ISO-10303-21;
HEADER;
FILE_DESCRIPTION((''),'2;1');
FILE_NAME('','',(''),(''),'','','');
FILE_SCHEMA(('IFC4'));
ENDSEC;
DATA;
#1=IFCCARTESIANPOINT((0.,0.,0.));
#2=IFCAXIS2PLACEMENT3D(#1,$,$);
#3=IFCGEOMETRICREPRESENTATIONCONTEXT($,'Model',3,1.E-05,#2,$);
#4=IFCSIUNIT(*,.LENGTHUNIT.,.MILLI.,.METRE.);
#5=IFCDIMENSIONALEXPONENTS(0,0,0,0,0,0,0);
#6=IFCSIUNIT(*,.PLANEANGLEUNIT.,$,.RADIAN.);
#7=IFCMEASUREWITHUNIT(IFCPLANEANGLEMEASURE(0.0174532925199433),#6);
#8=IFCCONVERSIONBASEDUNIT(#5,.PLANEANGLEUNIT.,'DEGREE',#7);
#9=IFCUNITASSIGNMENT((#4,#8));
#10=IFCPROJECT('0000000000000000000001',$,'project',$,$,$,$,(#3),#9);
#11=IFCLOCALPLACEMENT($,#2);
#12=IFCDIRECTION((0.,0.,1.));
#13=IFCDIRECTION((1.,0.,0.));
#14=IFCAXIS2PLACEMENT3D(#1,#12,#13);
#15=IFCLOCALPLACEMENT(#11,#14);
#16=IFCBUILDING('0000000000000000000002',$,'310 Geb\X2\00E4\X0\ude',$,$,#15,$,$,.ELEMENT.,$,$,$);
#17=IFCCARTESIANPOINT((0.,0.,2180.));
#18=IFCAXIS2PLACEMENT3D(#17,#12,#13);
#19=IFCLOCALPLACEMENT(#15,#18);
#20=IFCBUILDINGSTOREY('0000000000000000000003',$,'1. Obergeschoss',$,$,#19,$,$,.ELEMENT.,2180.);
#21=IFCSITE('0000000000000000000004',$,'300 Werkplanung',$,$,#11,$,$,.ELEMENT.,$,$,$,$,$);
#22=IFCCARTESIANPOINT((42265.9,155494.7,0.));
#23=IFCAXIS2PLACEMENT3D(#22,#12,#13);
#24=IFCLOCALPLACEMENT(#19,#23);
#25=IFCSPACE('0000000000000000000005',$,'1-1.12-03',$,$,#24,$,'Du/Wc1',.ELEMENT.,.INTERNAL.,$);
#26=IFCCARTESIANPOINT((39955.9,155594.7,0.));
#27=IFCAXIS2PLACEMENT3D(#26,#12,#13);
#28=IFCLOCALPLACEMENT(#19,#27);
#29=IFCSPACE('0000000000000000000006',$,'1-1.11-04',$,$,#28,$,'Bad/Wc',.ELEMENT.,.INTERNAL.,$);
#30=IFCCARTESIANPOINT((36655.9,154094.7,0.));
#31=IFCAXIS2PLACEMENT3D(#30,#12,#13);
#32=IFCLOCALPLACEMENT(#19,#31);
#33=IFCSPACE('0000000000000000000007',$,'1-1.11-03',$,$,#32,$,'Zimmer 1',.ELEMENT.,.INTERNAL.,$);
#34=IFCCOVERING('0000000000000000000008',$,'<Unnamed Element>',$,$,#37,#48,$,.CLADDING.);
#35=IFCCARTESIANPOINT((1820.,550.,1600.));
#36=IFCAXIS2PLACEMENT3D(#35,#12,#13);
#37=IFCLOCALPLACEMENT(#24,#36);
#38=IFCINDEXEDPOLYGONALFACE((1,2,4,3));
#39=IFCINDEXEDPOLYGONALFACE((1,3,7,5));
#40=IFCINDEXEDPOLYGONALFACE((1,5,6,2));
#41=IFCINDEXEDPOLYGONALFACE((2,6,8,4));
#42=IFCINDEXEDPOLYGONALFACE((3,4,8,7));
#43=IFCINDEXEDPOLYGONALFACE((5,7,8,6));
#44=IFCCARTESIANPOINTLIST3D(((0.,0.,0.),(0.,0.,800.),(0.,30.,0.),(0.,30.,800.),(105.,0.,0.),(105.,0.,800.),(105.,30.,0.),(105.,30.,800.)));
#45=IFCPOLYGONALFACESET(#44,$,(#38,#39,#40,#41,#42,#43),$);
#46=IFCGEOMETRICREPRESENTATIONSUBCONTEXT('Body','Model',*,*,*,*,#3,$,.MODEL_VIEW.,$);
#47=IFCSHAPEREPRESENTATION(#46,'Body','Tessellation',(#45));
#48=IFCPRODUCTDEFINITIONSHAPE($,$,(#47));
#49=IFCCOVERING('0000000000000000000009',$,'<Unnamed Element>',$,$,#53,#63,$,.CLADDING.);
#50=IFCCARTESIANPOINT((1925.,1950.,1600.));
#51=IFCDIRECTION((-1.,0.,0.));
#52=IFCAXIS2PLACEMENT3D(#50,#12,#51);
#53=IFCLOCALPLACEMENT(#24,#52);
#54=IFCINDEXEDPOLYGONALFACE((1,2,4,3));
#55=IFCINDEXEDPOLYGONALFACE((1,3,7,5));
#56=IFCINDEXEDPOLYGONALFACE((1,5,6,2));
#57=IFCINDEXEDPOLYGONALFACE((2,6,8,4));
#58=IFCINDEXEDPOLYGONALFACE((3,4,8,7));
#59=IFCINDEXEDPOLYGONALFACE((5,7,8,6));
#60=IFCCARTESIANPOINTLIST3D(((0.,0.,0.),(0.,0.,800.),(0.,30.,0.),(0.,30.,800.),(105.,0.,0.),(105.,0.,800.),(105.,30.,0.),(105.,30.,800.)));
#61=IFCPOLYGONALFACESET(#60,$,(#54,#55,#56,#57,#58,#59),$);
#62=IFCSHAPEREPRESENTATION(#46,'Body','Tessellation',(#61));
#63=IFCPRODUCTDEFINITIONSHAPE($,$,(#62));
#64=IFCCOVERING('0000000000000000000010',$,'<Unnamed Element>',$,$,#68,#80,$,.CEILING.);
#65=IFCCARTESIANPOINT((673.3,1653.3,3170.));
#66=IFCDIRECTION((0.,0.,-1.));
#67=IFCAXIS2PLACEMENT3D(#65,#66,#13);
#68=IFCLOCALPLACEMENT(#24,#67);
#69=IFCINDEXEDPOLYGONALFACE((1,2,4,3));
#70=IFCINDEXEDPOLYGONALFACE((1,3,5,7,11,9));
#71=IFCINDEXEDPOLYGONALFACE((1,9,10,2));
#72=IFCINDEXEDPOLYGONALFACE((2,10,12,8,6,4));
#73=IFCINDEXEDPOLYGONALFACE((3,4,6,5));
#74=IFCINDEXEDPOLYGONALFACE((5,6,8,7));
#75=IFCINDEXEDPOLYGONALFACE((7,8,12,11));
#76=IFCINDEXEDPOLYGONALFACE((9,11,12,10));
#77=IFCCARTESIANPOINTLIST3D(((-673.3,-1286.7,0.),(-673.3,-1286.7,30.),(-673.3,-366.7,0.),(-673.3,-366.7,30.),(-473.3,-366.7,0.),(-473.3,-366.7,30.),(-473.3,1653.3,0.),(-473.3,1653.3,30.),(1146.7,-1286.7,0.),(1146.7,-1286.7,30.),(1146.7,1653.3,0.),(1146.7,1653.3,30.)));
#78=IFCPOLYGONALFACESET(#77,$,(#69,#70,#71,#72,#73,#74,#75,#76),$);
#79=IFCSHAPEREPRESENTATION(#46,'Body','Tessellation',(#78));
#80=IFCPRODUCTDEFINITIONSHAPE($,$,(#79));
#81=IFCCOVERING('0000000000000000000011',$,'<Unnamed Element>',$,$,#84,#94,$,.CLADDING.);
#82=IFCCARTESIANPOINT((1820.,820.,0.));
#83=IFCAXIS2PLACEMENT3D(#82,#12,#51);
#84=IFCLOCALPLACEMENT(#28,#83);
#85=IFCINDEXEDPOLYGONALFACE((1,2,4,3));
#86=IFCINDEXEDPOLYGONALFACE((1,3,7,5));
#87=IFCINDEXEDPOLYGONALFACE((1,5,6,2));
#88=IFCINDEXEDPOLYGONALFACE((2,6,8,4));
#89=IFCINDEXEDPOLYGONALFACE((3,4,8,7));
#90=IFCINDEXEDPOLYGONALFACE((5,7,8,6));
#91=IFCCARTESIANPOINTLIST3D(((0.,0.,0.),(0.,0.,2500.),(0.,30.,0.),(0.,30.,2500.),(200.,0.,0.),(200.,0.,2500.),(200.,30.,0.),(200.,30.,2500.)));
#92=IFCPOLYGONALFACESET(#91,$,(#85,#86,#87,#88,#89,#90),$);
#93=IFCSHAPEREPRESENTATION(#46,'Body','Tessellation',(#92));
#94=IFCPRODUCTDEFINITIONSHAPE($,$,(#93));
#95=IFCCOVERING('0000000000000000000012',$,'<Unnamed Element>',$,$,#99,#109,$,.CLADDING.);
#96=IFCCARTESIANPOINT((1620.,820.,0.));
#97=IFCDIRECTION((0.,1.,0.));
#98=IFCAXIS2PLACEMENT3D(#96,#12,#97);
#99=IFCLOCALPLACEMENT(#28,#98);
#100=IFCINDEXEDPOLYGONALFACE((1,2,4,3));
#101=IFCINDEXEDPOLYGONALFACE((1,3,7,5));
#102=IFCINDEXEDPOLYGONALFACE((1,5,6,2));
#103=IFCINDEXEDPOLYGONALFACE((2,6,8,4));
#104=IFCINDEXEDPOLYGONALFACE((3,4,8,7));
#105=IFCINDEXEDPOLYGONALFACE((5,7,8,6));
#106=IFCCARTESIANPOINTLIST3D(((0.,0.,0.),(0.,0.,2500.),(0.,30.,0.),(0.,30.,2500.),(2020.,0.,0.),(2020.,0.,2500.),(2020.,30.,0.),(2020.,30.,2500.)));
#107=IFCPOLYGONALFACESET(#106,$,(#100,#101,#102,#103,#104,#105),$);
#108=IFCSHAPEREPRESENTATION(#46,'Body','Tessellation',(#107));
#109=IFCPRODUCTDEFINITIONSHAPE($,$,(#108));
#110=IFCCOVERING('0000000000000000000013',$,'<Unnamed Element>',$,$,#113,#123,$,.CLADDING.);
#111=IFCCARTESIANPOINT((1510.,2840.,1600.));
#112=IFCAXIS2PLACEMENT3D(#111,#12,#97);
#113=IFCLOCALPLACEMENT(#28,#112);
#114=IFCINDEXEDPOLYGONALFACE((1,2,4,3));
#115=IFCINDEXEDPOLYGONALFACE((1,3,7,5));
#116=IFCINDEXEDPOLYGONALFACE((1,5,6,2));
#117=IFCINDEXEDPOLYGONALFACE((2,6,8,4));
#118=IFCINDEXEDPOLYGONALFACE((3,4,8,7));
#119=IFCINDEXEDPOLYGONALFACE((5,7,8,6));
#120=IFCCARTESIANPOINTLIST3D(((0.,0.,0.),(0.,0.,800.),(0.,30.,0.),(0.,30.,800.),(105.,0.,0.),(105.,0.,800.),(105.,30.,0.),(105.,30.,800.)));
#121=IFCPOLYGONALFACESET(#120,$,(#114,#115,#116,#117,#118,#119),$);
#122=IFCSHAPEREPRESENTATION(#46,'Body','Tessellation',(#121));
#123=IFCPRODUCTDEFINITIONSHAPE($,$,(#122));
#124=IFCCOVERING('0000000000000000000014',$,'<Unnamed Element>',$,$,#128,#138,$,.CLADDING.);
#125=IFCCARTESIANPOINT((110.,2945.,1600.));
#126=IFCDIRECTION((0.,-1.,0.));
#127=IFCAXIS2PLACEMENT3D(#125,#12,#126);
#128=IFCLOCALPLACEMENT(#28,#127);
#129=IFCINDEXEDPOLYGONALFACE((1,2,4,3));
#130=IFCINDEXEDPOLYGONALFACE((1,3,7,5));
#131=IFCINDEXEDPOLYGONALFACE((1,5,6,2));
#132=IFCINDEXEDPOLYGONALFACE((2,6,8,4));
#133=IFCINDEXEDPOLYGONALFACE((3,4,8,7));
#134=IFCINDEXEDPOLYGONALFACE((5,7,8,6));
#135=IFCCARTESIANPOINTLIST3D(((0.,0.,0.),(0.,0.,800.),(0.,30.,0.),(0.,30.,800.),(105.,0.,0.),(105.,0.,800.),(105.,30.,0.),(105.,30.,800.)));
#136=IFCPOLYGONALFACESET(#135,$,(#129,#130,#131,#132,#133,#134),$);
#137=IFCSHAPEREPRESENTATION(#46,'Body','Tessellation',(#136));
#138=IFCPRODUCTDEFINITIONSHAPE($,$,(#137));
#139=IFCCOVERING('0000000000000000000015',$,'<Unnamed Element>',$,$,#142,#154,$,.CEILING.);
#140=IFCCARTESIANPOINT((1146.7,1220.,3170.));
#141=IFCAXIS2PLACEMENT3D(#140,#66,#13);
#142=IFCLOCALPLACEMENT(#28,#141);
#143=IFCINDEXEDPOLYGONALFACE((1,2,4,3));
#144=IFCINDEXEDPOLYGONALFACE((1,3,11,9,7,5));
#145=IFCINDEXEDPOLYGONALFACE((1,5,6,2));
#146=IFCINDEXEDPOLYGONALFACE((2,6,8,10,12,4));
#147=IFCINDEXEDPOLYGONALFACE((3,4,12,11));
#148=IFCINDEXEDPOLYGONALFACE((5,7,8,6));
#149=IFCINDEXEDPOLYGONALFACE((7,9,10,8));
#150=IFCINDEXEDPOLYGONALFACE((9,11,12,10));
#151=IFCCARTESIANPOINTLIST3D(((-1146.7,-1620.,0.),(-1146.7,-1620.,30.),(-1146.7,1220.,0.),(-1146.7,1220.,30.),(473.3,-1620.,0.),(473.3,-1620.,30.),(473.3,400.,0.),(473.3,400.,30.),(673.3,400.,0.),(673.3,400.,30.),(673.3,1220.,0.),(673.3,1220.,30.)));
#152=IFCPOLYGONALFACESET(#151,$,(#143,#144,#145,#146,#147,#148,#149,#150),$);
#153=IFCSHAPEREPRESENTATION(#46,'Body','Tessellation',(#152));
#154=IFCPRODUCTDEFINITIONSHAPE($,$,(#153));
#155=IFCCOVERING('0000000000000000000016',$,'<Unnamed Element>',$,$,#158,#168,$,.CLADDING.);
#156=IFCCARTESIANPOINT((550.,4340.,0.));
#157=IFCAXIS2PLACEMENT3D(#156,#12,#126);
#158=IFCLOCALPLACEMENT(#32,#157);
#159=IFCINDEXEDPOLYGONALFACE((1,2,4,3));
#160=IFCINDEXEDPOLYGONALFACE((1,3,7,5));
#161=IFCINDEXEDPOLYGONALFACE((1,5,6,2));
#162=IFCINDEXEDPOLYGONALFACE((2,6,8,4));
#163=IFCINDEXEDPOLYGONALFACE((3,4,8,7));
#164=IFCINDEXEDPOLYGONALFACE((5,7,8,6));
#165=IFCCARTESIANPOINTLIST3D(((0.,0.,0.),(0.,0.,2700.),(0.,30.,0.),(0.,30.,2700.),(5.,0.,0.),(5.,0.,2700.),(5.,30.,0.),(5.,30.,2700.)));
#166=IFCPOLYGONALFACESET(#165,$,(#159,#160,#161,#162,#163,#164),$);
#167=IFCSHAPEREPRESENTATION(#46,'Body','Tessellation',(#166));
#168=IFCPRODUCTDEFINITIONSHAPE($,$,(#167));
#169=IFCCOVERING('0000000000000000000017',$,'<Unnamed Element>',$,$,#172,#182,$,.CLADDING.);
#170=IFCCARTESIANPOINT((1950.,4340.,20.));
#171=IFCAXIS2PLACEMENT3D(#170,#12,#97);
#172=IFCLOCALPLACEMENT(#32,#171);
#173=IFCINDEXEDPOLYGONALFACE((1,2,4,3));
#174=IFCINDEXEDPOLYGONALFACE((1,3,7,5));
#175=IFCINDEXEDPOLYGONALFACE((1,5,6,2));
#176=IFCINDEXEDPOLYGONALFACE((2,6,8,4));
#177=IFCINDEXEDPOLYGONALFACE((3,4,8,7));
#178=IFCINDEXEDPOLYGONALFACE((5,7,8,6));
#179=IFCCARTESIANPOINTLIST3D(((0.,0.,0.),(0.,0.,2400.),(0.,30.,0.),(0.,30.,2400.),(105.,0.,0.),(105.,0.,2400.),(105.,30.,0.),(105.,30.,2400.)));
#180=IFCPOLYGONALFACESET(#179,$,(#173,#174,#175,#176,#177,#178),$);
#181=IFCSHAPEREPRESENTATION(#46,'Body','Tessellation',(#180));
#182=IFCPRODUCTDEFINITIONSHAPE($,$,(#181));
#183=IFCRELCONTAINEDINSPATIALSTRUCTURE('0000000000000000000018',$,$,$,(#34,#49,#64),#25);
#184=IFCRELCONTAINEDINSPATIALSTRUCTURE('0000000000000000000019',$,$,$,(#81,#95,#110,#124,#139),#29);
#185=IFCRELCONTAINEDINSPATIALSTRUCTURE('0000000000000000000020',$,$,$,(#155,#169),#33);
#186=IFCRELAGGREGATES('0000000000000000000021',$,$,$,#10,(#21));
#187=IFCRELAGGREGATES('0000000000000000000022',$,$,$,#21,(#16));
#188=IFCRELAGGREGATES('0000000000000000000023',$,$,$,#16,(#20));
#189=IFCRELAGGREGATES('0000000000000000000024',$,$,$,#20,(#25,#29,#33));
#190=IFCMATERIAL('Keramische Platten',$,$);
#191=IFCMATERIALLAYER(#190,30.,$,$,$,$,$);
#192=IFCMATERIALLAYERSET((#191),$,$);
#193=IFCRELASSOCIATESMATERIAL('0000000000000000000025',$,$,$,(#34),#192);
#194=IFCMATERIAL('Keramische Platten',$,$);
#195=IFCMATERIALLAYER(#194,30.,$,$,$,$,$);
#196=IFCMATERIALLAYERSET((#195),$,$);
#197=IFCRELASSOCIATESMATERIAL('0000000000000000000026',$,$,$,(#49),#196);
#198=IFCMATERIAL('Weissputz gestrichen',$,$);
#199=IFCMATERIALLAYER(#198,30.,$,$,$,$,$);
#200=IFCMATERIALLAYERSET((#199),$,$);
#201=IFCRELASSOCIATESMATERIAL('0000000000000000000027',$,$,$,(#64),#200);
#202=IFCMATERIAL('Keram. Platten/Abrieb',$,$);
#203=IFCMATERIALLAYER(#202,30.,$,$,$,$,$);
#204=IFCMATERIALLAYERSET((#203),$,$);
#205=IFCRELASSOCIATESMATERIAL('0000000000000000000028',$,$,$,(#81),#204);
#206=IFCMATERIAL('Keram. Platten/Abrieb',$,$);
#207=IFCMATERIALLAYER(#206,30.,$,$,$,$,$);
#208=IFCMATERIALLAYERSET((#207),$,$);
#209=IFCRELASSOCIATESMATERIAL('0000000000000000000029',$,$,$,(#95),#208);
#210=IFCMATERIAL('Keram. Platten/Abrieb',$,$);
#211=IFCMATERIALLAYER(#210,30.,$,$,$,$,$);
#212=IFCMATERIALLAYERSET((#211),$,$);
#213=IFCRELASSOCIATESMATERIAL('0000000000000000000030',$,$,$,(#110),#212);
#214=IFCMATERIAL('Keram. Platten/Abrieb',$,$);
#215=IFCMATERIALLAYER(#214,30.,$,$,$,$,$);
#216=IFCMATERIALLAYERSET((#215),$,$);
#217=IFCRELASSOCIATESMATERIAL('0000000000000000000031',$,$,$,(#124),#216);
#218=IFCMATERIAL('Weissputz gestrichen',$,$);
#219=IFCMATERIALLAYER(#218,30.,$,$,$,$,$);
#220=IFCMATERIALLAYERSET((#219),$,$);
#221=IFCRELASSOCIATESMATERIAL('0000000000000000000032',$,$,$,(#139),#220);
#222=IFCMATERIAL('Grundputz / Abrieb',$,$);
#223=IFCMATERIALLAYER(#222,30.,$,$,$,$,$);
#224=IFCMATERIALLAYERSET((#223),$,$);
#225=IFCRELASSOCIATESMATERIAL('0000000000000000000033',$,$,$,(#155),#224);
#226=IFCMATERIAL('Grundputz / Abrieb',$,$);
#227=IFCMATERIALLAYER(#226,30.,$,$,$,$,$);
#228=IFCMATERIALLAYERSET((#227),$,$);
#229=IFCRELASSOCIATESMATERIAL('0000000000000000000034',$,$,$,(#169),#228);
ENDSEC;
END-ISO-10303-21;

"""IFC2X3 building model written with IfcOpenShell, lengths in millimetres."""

from ifc_helpers import new_model, entity, si_unit, converted_unit, frame, frame_2d, origin, origin_with_axes, place, context, subcontext, project, spatial, polyline, rectangle, outline, extrude, material, layer, layer_set, layer_usage, element, save


model = new_model("IFC2X3")

# Units and contexts
model_context = context("Model", 3, precision=1e-05, world=origin())
body_context = subcontext(model_context, "Body", "Model", "MODEL_VIEW")
ifc_project = project(units=[si_unit("LENGTHUNIT", "METRE", prefix="MILLI"), converted_unit("PLANEANGLEUNIT", "DEGREE", entity("IfcPlaneAngleMeasure", 0.0174532925199433), si_unit("PLANEANGLEUNIT", "RADIAN"), dimensions=[0, 0, 0, 0, 0, 0, 0])], contexts=[model_context])

# Site, building, storey
site_placement = place(None, origin())
site = spatial("IfcSite", under=ifc_project, at=site_placement, Name="300 Werkplanung", CompositionType="ELEMENT")
building_placement = place(site_placement, origin_with_axes())
building = spatial("IfcBuilding", under=site, at=building_placement, Name="310 Gebäude", CompositionType="ELEMENT")
storey_placement = place(building_placement, frame((0.0, 0.0, 2180.0), z_axis=(0.0, 0.0, 1.0), x_axis=(1.0, 0.0, 0.0)))
storey = spatial("IfcBuildingStorey", under=building, at=storey_placement, Name="1. Obergeschoss", CompositionType="ELEMENT", Elevation=2180.0)

# Shared definitions
space_1_placement = place(storey_placement, frame((42265.9, 155494.7, 0.0), z_axis=(0.0, 0.0, 1.0), x_axis=(1.0, 0.0, 0.0)))
space_1 = spatial("IfcSpace", under=storey, at=space_1_placement, Name="1-1.12-03", LongName="Du/Wc1", CompositionType="ELEMENT", InteriorOrExteriorSpace="INTERNAL")

# Coverings
ifc_material_1 = material(Name="Keramische Platten")
ifc_layer_1 = layer(ifc_material_1, 30.0)
ifc_layer_set_1 = layer_set([ifc_layer_1])
ifc_layer_usage_1 = layer_usage(ifc_layer_set_1, "AXIS3", "POSITIVE", 0.0)
covering_1_placement = place(space_1_placement, frame((1820.0, 550.0, 1600.0), z_axis=(0.0, 0.0, 1.0), x_axis=(1.0, 0.0, 0.0)))
element("IfcCovering", 1, at=covering_1_placement, inside=space_1, material=ifc_layer_usage_1, Name="<Unnamed Element>", PredefinedType="CLADDING", context=body_context, shape_type="SweptSolid", body=[
    extrude(rectangle(XDim=800.0, YDim=105.0, at=frame_2d((-52.5, 400.0), x_axis=(0.0, 1.0))), frame((105.0, 0.0, 800.0), z_axis=(0.0, 1.0, 0.0), x_axis=(1.0, 0.0, 0.0)), (0.0, 0.0, 1.0), 30.0),
])
ifc_material_2 = material(Name="Keramische Platten")
ifc_layer_2 = layer(ifc_material_2, 30.0)
ifc_layer_set_2 = layer_set([ifc_layer_2])
ifc_layer_usage_2 = layer_usage(ifc_layer_set_2, "AXIS3", "POSITIVE", 0.0)
covering_2_placement = place(space_1_placement, frame((1925.0, 1950.0, 1600.0), z_axis=(0.0, 0.0, 1.0), x_axis=(-1.0, 0.0, 0.0)))
element("IfcCovering", 2, at=covering_2_placement, inside=space_1, material=ifc_layer_usage_2, Name="<Unnamed Element>", PredefinedType="CLADDING", context=body_context, shape_type="SweptSolid", body=[
    extrude(rectangle(XDim=800.0, YDim=105.0, at=frame_2d((-52.5, 400.0), x_axis=(0.0, 1.0))), frame((105.0, 0.0, 800.0), z_axis=(0.0, 1.0, 0.0), x_axis=(1.0, 0.0, 0.0)), (0.0, 0.0, 1.0), 30.0),
])
ifc_material_3 = material(Name="Weissputz gestrichen")
ifc_layer_3 = layer(ifc_material_3, 30.0)
ifc_layer_set_3 = layer_set([ifc_layer_3])
ifc_layer_usage_3 = layer_usage(ifc_layer_set_3, "AXIS3", "POSITIVE", 0.0)
covering_3_placement = place(space_1_placement, frame((673.3, 1653.3, 3170.0), z_axis=(0.0, 0.0, -1.0), x_axis=(1.0, 0.0, 0.0)))
element("IfcCovering", 3, at=covering_3_placement, inside=space_1, material=ifc_layer_usage_3, Name="<Unnamed Element>", PredefinedType="CEILING", context=body_context, shape_type="SweptSolid", body=[
    extrude(outline(polyline([(-673.3, -1286.7), (1146.7, -1286.7), (1146.7, 1653.3), (-473.3, 1653.3), (-473.3, -366.7), (-673.3, -366.7), (-673.3, -1286.7)])), origin_with_axes(), (0.0, 0.0, 1.0), 30.0),
])

# Shared definitions
space_2_placement = place(storey_placement, frame((39955.9, 155594.7, 0.0), z_axis=(0.0, 0.0, 1.0), x_axis=(1.0, 0.0, 0.0)))
space_2 = spatial("IfcSpace", under=storey, at=space_2_placement, Name="1-1.11-04", LongName="Bad/Wc", CompositionType="ELEMENT", InteriorOrExteriorSpace="INTERNAL")

# Coverings
ifc_material_4 = material(Name="Keram. Platten/Abrieb")
ifc_layer_4 = layer(ifc_material_4, 30.0)
ifc_layer_set_4 = layer_set([ifc_layer_4])
ifc_layer_usage_4 = layer_usage(ifc_layer_set_4, "AXIS3", "POSITIVE", 0.0)
covering_4_placement = place(space_2_placement, frame((1820.0, 820.0, 0.0), z_axis=(0.0, 0.0, 1.0), x_axis=(-1.0, 0.0, 0.0)))
element("IfcCovering", 4, at=covering_4_placement, inside=space_2, material=ifc_layer_usage_4, Name="<Unnamed Element>", PredefinedType="CLADDING", context=body_context, shape_type="SweptSolid", body=[
    extrude(rectangle(XDim=2500.0, YDim=200.0, at=frame_2d((-100.0, 1250.0), x_axis=(0.0, 1.0))), frame((200.0, 0.0, 2500.0), z_axis=(0.0, 1.0, 0.0), x_axis=(1.0, 0.0, 0.0)), (0.0, 0.0, 1.0), 30.0),
])
ifc_material_5 = material(Name="Keram. Platten/Abrieb")
ifc_layer_5 = layer(ifc_material_5, 30.0)
ifc_layer_set_5 = layer_set([ifc_layer_5])
ifc_layer_usage_5 = layer_usage(ifc_layer_set_5, "AXIS3", "POSITIVE", 0.0)
covering_5_placement = place(space_2_placement, frame((1620.0, 820.0, 0.0), z_axis=(0.0, 0.0, 1.0), x_axis=(0.0, 1.0, 0.0)))
element("IfcCovering", 5, at=covering_5_placement, inside=space_2, material=ifc_layer_usage_5, Name="<Unnamed Element>", PredefinedType="CLADDING", context=body_context, shape_type="SweptSolid", body=[
    extrude(rectangle(XDim=2500.0, YDim=2020.0, at=frame_2d((-1010.0, 1250.0), x_axis=(0.0, 1.0))), frame((2020.0, 0.0, 2500.0), z_axis=(0.0, 1.0, 0.0), x_axis=(1.0, 0.0, 0.0)), (0.0, 0.0, 1.0), 30.0),
])
ifc_material_6 = material(Name="Keram. Platten/Abrieb")
ifc_layer_6 = layer(ifc_material_6, 30.0)
ifc_layer_set_6 = layer_set([ifc_layer_6])
ifc_layer_usage_6 = layer_usage(ifc_layer_set_6, "AXIS3", "POSITIVE", 0.0)
covering_6_placement = place(space_2_placement, frame((1510.0, 2840.0, 1600.0), z_axis=(0.0, 0.0, 1.0), x_axis=(0.0, 1.0, 0.0)))
element("IfcCovering", 6, at=covering_6_placement, inside=space_2, material=ifc_layer_usage_6, Name="<Unnamed Element>", PredefinedType="CLADDING", context=body_context, shape_type="SweptSolid", body=[
    extrude(rectangle(XDim=800.0, YDim=105.0, at=frame_2d((-52.5, 400.0), x_axis=(0.0, 1.0))), frame((105.0, 0.0, 800.0), z_axis=(0.0, 1.0, 0.0), x_axis=(1.0, 0.0, 0.0)), (0.0, 0.0, 1.0), 30.0),
])
ifc_material_7 = material(Name="Keram. Platten/Abrieb")
ifc_layer_7 = layer(ifc_material_7, 30.0)
ifc_layer_set_7 = layer_set([ifc_layer_7])
ifc_layer_usage_7 = layer_usage(ifc_layer_set_7, "AXIS3", "POSITIVE", 0.0)
covering_7_placement = place(space_2_placement, frame((110.0, 2945.0, 1600.0), z_axis=(0.0, 0.0, 1.0), x_axis=(0.0, -1.0, 0.0)))
element("IfcCovering", 7, at=covering_7_placement, inside=space_2, material=ifc_layer_usage_7, Name="<Unnamed Element>", PredefinedType="CLADDING", context=body_context, shape_type="SweptSolid", body=[
    extrude(rectangle(XDim=800.0, YDim=105.0, at=frame_2d((-52.5, 400.0), x_axis=(0.0, 1.0))), frame((105.0, 0.0, 800.0), z_axis=(0.0, 1.0, 0.0), x_axis=(1.0, 0.0, 0.0)), (0.0, 0.0, 1.0), 30.0),
])
ifc_material_8 = material(Name="Weissputz gestrichen")
ifc_layer_8 = layer(ifc_material_8, 30.0)
ifc_layer_set_8 = layer_set([ifc_layer_8])
ifc_layer_usage_8 = layer_usage(ifc_layer_set_8, "AXIS3", "POSITIVE", 0.0)
covering_8_placement = place(space_2_placement, frame((1146.7, 1220.0, 3170.0), z_axis=(0.0, 0.0, -1.0), x_axis=(1.0, 0.0, 0.0)))
element("IfcCovering", 8, at=covering_8_placement, inside=space_2, material=ifc_layer_usage_8, Name="<Unnamed Element>", PredefinedType="CEILING", context=body_context, shape_type="SweptSolid", body=[
    extrude(outline(polyline([(-1146.7, -1620.0), (473.3, -1620.0), (473.3, 400.0), (673.3, 400.0), (673.3, 1220.0), (-1146.7, 1220.0), (-1146.7, -1620.0)])), origin_with_axes(), (0.0, 0.0, 1.0), 30.0),
])

# Shared definitions
space_3_placement = place(storey_placement, frame((36655.9, 154094.7, 0.0), z_axis=(0.0, 0.0, 1.0), x_axis=(1.0, 0.0, 0.0)))
space_3 = spatial("IfcSpace", under=storey, at=space_3_placement, Name="1-1.11-03", LongName="Zimmer 1", CompositionType="ELEMENT", InteriorOrExteriorSpace="INTERNAL")

# Coverings
ifc_material_9 = material(Name="Grundputz / Abrieb")
ifc_layer_9 = layer(ifc_material_9, 30.0)
ifc_layer_set_9 = layer_set([ifc_layer_9])
ifc_layer_usage_9 = layer_usage(ifc_layer_set_9, "AXIS3", "POSITIVE", 0.0)
covering_9_placement = place(space_3_placement, frame((550.0, 4340.0, 0.0), z_axis=(0.0, 0.0, 1.0), x_axis=(0.0, -1.0, 0.0)))
element("IfcCovering", 9, at=covering_9_placement, inside=space_3, material=ifc_layer_usage_9, Name="<Unnamed Element>", PredefinedType="CLADDING", context=body_context, shape_type="SweptSolid", body=[
    extrude(rectangle(XDim=2700.0, YDim=5.0, at=frame_2d((-2.5, 1350.0), x_axis=(0.0, 1.0))), frame((5.0, 0.0, 2700.0), z_axis=(0.0, 1.0, 0.0), x_axis=(1.0, 0.0, 0.0)), (0.0, 0.0, 1.0), 30.0),
])
ifc_material_10 = material(Name="Grundputz / Abrieb")
ifc_layer_10 = layer(ifc_material_10, 30.0)
ifc_layer_set_10 = layer_set([ifc_layer_10])
ifc_layer_usage_10 = layer_usage(ifc_layer_set_10, "AXIS3", "POSITIVE", 0.0)
covering_10_placement = place(space_3_placement, frame((1950.0, 4340.0, 20.0), z_axis=(0.0, 0.0, 1.0), x_axis=(0.0, 1.0, 0.0)))
element("IfcCovering", 10, at=covering_10_placement, inside=space_3, material=ifc_layer_usage_10, Name="<Unnamed Element>", PredefinedType="CLADDING", context=body_context, shape_type="SweptSolid", body=[
    extrude(rectangle(XDim=2400.0, YDim=105.0, at=frame_2d((-52.5, 1200.0), x_axis=(0.0, 1.0))), frame((105.0, 0.0, 2400.0), z_axis=(0.0, 1.0, 0.0), x_axis=(1.0, 0.0, 0.0)), (0.0, 0.0, 1.0), 30.0),
])

save(model, "model.ifc")
